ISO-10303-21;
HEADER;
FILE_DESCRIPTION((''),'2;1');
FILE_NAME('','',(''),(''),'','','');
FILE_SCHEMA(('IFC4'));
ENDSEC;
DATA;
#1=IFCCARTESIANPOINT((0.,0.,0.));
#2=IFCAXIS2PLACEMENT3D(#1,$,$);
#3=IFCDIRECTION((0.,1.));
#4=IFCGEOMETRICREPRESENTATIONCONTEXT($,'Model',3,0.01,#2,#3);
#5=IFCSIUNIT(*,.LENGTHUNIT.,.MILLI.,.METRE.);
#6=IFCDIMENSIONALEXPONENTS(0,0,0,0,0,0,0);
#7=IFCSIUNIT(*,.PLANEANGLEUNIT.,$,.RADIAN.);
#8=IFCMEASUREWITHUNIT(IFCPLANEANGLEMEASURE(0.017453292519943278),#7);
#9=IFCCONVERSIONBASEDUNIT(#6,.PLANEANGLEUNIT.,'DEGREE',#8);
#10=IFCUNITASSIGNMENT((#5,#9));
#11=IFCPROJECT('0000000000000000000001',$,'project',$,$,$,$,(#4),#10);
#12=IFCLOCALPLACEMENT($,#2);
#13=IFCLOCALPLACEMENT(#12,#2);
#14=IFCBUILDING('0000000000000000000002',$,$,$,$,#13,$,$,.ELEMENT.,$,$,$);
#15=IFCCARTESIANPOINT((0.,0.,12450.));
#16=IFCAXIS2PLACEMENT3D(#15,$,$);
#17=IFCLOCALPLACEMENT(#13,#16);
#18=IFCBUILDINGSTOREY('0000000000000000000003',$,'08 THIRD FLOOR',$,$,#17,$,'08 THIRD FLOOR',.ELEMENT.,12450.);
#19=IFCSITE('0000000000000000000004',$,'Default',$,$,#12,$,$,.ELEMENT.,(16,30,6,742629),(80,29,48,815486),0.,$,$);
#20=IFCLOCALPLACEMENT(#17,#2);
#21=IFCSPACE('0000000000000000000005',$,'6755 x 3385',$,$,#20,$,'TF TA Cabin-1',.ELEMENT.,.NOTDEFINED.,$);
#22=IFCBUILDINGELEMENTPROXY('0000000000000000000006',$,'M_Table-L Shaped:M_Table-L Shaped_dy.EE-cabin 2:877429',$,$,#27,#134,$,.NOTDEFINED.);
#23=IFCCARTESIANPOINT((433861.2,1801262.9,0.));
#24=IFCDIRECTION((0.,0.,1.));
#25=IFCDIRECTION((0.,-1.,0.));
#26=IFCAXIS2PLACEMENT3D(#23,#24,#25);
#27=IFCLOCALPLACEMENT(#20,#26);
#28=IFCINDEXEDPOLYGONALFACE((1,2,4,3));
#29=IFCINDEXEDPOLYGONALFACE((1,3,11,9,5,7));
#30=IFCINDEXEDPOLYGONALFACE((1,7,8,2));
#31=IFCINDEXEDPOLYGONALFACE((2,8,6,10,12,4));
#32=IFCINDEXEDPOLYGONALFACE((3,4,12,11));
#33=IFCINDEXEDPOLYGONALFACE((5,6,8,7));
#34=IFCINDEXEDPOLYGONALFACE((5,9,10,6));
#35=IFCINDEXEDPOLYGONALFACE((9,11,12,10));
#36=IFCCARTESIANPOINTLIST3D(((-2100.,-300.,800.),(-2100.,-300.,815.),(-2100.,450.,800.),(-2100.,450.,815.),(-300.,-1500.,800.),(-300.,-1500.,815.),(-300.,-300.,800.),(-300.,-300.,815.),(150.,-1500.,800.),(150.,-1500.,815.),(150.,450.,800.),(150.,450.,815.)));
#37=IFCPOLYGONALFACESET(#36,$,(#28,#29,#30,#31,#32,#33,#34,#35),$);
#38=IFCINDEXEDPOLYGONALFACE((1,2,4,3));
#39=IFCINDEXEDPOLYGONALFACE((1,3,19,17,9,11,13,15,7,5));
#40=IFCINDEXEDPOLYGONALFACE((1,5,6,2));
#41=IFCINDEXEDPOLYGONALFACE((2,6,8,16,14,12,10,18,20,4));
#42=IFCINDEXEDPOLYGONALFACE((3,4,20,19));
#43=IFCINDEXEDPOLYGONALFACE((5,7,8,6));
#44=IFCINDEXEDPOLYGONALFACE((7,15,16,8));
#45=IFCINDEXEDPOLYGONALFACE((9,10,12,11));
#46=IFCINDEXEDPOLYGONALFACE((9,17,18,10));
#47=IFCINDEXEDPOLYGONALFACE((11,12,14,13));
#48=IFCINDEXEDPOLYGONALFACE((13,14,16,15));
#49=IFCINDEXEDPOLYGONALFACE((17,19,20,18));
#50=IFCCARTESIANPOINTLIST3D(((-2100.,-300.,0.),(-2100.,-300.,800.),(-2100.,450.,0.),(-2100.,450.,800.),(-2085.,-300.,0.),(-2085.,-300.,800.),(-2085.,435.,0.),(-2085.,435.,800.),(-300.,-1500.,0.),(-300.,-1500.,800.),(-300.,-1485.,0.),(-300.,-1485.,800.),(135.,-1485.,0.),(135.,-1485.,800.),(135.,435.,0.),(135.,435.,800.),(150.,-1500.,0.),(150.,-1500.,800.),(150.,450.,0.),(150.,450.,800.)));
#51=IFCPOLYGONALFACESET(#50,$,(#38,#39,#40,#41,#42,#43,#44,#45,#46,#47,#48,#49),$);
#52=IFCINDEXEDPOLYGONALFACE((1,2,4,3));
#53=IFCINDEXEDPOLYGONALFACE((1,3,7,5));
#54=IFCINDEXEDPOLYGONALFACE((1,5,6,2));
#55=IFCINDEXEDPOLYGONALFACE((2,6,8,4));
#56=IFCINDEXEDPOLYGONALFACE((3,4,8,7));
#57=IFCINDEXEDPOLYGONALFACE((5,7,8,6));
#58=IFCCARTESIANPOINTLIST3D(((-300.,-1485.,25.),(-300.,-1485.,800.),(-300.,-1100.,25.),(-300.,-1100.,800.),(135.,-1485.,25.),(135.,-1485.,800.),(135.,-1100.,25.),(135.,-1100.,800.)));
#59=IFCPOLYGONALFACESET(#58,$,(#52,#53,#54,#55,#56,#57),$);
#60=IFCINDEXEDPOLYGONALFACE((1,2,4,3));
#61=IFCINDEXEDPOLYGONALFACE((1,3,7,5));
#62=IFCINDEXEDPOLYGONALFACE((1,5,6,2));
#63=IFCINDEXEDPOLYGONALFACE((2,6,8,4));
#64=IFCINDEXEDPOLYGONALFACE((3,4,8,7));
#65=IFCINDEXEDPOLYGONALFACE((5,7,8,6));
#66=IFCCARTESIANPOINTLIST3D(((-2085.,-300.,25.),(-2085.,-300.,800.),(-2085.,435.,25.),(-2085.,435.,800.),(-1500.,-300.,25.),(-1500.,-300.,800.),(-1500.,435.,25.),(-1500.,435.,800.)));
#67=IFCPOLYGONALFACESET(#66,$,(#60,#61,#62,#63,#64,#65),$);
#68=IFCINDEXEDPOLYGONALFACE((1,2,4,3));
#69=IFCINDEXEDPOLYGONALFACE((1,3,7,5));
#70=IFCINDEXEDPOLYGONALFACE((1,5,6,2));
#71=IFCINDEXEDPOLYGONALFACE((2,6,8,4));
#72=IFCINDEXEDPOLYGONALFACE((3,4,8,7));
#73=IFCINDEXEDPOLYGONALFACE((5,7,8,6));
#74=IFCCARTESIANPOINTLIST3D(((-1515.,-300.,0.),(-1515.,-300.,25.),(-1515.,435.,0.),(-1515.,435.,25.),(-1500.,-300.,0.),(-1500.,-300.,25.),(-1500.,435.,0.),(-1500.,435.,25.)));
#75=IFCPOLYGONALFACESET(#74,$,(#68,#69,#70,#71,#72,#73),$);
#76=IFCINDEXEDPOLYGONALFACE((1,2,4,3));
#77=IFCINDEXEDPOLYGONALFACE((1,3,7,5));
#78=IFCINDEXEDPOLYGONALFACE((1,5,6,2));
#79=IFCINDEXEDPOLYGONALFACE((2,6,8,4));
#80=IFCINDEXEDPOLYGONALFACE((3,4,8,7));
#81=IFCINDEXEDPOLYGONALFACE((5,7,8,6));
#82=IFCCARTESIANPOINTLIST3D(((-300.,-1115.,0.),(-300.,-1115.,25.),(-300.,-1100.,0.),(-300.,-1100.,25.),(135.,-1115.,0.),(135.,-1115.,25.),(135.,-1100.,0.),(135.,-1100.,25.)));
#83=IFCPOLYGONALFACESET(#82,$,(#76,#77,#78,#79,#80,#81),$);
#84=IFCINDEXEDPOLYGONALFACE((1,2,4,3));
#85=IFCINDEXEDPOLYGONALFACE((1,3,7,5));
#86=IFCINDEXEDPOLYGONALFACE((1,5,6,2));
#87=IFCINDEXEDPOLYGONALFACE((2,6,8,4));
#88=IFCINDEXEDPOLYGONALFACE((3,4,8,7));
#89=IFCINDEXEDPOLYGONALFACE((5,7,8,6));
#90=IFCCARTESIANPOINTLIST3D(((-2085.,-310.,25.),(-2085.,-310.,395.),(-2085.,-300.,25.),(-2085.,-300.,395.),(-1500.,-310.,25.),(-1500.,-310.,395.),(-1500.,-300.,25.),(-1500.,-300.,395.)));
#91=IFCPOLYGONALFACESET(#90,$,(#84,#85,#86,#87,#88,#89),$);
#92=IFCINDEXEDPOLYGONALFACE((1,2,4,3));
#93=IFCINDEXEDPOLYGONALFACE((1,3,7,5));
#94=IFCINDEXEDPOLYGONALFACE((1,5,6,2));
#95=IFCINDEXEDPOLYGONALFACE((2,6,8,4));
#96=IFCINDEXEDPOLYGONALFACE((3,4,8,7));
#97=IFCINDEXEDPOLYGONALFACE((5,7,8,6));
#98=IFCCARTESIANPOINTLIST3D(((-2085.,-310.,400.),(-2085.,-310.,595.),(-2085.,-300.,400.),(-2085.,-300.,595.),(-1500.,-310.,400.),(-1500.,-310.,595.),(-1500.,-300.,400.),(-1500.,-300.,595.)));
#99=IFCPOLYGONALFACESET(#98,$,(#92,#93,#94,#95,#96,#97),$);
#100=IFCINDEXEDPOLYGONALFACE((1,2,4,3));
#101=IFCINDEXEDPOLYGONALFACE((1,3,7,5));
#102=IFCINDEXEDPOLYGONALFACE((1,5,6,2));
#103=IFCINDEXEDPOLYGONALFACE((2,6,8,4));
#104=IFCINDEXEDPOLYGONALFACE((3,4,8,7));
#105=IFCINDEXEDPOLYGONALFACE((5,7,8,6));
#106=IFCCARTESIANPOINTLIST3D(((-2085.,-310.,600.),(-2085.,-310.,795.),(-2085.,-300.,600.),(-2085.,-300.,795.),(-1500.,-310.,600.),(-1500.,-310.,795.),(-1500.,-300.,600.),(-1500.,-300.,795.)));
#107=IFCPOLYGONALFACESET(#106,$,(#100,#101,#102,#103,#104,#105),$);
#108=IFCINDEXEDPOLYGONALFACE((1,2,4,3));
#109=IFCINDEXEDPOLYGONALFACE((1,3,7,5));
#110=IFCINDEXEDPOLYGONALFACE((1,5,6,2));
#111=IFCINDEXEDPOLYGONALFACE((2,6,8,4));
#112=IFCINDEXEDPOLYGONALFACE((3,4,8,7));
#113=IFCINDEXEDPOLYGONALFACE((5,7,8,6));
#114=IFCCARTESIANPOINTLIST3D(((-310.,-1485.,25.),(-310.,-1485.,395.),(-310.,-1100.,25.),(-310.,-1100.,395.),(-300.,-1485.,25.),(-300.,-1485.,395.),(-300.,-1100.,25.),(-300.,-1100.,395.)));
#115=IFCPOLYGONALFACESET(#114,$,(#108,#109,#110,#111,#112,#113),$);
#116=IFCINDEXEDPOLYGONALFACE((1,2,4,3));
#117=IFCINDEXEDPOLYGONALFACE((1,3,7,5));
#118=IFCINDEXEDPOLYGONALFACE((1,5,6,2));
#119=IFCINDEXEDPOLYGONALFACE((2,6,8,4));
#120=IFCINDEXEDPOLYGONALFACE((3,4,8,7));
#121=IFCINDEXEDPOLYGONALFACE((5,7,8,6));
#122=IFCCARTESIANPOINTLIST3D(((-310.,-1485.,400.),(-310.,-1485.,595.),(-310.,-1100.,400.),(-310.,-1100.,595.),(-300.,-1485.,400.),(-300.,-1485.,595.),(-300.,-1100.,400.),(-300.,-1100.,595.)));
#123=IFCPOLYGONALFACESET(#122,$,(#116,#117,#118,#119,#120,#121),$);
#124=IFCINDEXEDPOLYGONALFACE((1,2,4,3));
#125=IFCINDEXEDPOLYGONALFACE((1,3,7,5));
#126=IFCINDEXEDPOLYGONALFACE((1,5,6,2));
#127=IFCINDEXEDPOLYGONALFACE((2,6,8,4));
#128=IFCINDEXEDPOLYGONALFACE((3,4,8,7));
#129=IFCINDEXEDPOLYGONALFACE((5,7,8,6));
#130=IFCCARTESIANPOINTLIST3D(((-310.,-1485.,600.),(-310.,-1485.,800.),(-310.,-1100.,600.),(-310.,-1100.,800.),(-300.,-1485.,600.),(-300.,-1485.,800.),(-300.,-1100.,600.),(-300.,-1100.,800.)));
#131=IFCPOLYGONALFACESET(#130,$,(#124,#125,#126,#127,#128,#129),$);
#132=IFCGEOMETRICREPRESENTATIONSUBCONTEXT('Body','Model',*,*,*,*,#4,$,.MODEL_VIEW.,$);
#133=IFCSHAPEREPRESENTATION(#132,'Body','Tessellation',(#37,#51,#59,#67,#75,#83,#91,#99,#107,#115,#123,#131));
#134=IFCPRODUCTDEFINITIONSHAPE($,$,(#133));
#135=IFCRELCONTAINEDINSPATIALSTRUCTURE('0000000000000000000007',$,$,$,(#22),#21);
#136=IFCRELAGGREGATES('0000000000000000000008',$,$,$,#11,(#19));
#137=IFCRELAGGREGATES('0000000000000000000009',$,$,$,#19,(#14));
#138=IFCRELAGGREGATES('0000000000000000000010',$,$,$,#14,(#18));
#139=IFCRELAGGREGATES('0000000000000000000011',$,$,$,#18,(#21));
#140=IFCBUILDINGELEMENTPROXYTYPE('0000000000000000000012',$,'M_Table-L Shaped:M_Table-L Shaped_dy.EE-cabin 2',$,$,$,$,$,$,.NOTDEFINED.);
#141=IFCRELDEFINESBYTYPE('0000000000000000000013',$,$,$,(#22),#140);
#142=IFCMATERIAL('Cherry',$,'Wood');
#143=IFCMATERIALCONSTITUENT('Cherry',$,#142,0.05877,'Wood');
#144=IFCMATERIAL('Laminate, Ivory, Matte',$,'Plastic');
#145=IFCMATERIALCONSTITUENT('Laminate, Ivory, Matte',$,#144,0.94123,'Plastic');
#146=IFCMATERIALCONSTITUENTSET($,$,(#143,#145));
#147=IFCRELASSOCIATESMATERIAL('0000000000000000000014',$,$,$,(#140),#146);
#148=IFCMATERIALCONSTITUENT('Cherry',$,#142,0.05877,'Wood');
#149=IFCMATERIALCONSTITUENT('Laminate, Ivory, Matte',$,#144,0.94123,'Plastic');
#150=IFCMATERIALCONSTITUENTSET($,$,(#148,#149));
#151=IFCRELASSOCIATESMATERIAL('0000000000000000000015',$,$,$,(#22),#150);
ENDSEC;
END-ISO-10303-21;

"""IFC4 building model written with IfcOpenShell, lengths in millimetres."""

from ifc_helpers import new_model, entity, si_unit, converted_unit, direction, frame, origin, place, context, subcontext, project, spatial, indexed_curve, outline, extrude, source, transform, mapped, material, constituent, constituent_set, type_object, type_shapes, element, save


model = new_model("IFC4")

# Units and contexts
model_context = context("Model", 3, precision=0.01, world=origin(), true_north=direction((0.0, 1.0)))
body_context = subcontext(model_context, "Body", "Model", "MODEL_VIEW")
ifc_project = project(units=[si_unit("LENGTHUNIT", "METRE", prefix="MILLI"), converted_unit("PLANEANGLEUNIT", "DEGREE", entity("IfcPlaneAngleMeasure", 0.017453292519943278), si_unit("PLANEANGLEUNIT", "RADIAN"), dimensions=[0, 0, 0, 0, 0, 0, 0])], contexts=[model_context])

# Site, building, storey
site_placement = place(None, origin())
site = spatial("IfcSite", under=ifc_project, at=site_placement, Name="Default", CompositionType="ELEMENT", RefLatitude=(16, 30, 6, 742629), RefLongitude=(80, 29, 48, 815486), RefElevation=0.0)
building_placement = place(site_placement, origin())
building = spatial("IfcBuilding", under=site, at=building_placement, CompositionType="ELEMENT")
storey_placement = place(building_placement, frame((0.0, 0.0, 12450.0)))
storey = spatial("IfcBuildingStorey", under=building, at=storey_placement, Name="08 THIRD FLOOR", LongName="08 THIRD FLOOR", CompositionType="ELEMENT", Elevation=12450.0)

# Shared definitions
space_1_placement = place(storey_placement, origin())
space_1 = spatial("IfcSpace", under=storey, at=space_1_placement, Name="6755 x 3385", LongName="TF TA Cabin-1", CompositionType="ELEMENT", PredefinedType="NOTDEFINED")

# Shared definitions
ifc_material_1 = material(Name="Laminate, Ivory, Matte", Category="Plastic")

# Building element proxy
ifc_material_2 = material(Name="Cherry", Category="Wood")
ifc_constituent_1 = constituent(ifc_material_2, Name="Cherry", Category="Wood", fraction=0.05877)
ifc_constituent_2 = constituent(ifc_material_1, Name="Laminate, Ivory, Matte", Category="Plastic", fraction=0.94123)
ifc_constituent_set_1 = constituent_set(constituents=[ifc_constituent_1, ifc_constituent_2])
ifc_constituent_3 = constituent(ifc_material_2, Name="Cherry", Category="Wood", fraction=0.05877)
ifc_constituent_4 = constituent(ifc_material_1, Name="Laminate, Ivory, Matte", Category="Plastic", fraction=0.94123)
ifc_constituent_set_2 = constituent_set(constituents=[ifc_constituent_3, ifc_constituent_4])
building_element_proxy_type_1 = type_object("IfcBuildingElementProxyType", Name="M_Table-L Shaped:M_Table-L Shaped_dy.EE-cabin 2", PredefinedType="NOTDEFINED", material=ifc_constituent_set_2)
shared_shape_1 = source(origin(), body_context, "Body", "SweptSolid", [
    extrude(outline(indexed_curve([(450.0, -1050.0), (900.0, -1050.0), (900.0, 900.0), (-1350.0, 900.0), (-1350.0, 150.0), (450.0, 150.0), (450.0, -1050.0)], self_intersect=False)), frame((-750.0, -450.0, 800.0)), (0.0, 0.0, 1.0), 15.0),
    extrude(outline(indexed_curve([(540.0, -1020.0), (990.0, -1020.0), (990.0, 930.0), (-1260.0, 930.0), (-1260.0, 180.0), (-1245.0, 180.0), (-1245.0, 915.0), (975.0, 915.0), (975.0, -1005.0), (540.0, -1005.0), (540.0, -1020.0)], self_intersect=False)), frame((-840.0, -480.0, 0.0)), (0.0, 0.0, 1.0), 800.0),
    extrude(outline(indexed_curve([(-192.5, -217.5), (192.5, -217.5), (192.5, 217.5), (-192.5, 217.5), (-192.5, -217.5)], self_intersect=False)), frame((-82.5, -1292.5, 25.0), z_axis=(0.0, 0.0, 1.0), x_axis=(0.0, 1.0, 0.0)), (0.0, 0.0, 1.0), 775.0),
    extrude(outline(indexed_curve([(-292.5, -367.5), (292.5, -367.5), (292.5, 367.5), (-292.5, 367.5), (-292.5, -367.5)], self_intersect=False)), frame((-1792.5, 67.5, 25.0)), (0.0, 0.0, 1.0), 775.0),
    extrude(outline(indexed_curve([(-367.5, -7.5), (367.5, -7.5), (367.5, 7.5), (-367.5, 7.5), (-367.5, -7.5)], self_intersect=False)), frame((-1507.5, 67.5, 0.0), z_axis=(0.0, 0.0, 1.0), x_axis=(0.0, 1.0, 0.0)), (0.0, 0.0, 1.0), 25.0),
    extrude(outline(indexed_curve([(-217.5, -7.5), (217.5, -7.5), (217.5, 7.5), (-217.5, 7.5), (-217.5, -7.5)], self_intersect=False)), frame((-82.5, -1107.5, 0.0), z_axis=(0.0, 0.0, 1.0), x_axis=(-1.0, 0.0, 0.0)), (0.0, 0.0, 1.0), 25.0),
    extrude(outline(indexed_curve([(-292.5, -5.0), (292.5, -5.0), (292.5, 5.0), (-292.5, 5.0), (-292.5, -5.0)], self_intersect=False)), frame((-1792.5, -305.0, 25.0), z_axis=(0.0, 0.0, 1.0), x_axis=(-1.0, 0.0, 0.0)), (0.0, 0.0, 1.0), 370.0),
    extrude(outline(indexed_curve([(-292.5, -5.0), (292.5, -5.0), (292.5, 5.0), (-292.5, 5.0), (-292.5, -5.0)], self_intersect=False)), frame((-1792.5, -305.0, 400.0), z_axis=(0.0, 0.0, 1.0), x_axis=(-1.0, 0.0, 0.0)), (0.0, 0.0, 1.0), 195.0),
    extrude(outline(indexed_curve([(-292.5, -5.0), (292.5, -5.0), (292.5, 5.0), (-292.5, 5.0), (-292.5, -5.0)], self_intersect=False)), frame((-1792.5, -305.0, 600.0), z_axis=(0.0, 0.0, 1.0), x_axis=(-1.0, 0.0, 0.0)), (0.0, 0.0, 1.0), 195.0),
    extrude(outline(indexed_curve([(-5.0, -192.5), (5.0, -192.5), (5.0, 192.5), (-5.0, 192.5), (-5.0, -192.5)], self_intersect=False)), frame((-305.0, -1292.5, 25.0)), (0.0, 0.0, 1.0), 370.0),
    extrude(outline(indexed_curve([(-5.0, -192.5), (5.0, -192.5), (5.0, 192.5), (-5.0, 192.5), (-5.0, -192.5)], self_intersect=False)), frame((-305.0, -1292.5, 400.0)), (0.0, 0.0, 1.0), 195.0),
    extrude(outline(indexed_curve([(-5.0, -192.5), (5.0, -192.5), (5.0, 192.5), (-5.0, 192.5), (-5.0, -192.5)], self_intersect=False)), frame((-305.0, -1292.5, 600.0)), (0.0, 0.0, 1.0), 200.0),
])
type_shapes(building_element_proxy_type_1, [shared_shape_1])
proxy_1_placement = place(space_1_placement, frame((433861.2, 1801262.9, 0.0), z_axis=(0.0, 0.0, 1.0), x_axis=(0.0, -1.0, 0.0)))
element("IfcBuildingElementProxy", 1, at=proxy_1_placement, inside=space_1, type_object=building_element_proxy_type_1, material=ifc_constituent_set_1, Name="M_Table-L Shaped:M_Table-L Shaped_dy.EE-cabin 2:877429", PredefinedType="NOTDEFINED", context=body_context, shape_type="MappedRepresentation", body=[
    mapped(shared_shape_1, transform((0.0, 0.0, 0.0), scale=1.0)),
])

save(model, "model.ifc")
